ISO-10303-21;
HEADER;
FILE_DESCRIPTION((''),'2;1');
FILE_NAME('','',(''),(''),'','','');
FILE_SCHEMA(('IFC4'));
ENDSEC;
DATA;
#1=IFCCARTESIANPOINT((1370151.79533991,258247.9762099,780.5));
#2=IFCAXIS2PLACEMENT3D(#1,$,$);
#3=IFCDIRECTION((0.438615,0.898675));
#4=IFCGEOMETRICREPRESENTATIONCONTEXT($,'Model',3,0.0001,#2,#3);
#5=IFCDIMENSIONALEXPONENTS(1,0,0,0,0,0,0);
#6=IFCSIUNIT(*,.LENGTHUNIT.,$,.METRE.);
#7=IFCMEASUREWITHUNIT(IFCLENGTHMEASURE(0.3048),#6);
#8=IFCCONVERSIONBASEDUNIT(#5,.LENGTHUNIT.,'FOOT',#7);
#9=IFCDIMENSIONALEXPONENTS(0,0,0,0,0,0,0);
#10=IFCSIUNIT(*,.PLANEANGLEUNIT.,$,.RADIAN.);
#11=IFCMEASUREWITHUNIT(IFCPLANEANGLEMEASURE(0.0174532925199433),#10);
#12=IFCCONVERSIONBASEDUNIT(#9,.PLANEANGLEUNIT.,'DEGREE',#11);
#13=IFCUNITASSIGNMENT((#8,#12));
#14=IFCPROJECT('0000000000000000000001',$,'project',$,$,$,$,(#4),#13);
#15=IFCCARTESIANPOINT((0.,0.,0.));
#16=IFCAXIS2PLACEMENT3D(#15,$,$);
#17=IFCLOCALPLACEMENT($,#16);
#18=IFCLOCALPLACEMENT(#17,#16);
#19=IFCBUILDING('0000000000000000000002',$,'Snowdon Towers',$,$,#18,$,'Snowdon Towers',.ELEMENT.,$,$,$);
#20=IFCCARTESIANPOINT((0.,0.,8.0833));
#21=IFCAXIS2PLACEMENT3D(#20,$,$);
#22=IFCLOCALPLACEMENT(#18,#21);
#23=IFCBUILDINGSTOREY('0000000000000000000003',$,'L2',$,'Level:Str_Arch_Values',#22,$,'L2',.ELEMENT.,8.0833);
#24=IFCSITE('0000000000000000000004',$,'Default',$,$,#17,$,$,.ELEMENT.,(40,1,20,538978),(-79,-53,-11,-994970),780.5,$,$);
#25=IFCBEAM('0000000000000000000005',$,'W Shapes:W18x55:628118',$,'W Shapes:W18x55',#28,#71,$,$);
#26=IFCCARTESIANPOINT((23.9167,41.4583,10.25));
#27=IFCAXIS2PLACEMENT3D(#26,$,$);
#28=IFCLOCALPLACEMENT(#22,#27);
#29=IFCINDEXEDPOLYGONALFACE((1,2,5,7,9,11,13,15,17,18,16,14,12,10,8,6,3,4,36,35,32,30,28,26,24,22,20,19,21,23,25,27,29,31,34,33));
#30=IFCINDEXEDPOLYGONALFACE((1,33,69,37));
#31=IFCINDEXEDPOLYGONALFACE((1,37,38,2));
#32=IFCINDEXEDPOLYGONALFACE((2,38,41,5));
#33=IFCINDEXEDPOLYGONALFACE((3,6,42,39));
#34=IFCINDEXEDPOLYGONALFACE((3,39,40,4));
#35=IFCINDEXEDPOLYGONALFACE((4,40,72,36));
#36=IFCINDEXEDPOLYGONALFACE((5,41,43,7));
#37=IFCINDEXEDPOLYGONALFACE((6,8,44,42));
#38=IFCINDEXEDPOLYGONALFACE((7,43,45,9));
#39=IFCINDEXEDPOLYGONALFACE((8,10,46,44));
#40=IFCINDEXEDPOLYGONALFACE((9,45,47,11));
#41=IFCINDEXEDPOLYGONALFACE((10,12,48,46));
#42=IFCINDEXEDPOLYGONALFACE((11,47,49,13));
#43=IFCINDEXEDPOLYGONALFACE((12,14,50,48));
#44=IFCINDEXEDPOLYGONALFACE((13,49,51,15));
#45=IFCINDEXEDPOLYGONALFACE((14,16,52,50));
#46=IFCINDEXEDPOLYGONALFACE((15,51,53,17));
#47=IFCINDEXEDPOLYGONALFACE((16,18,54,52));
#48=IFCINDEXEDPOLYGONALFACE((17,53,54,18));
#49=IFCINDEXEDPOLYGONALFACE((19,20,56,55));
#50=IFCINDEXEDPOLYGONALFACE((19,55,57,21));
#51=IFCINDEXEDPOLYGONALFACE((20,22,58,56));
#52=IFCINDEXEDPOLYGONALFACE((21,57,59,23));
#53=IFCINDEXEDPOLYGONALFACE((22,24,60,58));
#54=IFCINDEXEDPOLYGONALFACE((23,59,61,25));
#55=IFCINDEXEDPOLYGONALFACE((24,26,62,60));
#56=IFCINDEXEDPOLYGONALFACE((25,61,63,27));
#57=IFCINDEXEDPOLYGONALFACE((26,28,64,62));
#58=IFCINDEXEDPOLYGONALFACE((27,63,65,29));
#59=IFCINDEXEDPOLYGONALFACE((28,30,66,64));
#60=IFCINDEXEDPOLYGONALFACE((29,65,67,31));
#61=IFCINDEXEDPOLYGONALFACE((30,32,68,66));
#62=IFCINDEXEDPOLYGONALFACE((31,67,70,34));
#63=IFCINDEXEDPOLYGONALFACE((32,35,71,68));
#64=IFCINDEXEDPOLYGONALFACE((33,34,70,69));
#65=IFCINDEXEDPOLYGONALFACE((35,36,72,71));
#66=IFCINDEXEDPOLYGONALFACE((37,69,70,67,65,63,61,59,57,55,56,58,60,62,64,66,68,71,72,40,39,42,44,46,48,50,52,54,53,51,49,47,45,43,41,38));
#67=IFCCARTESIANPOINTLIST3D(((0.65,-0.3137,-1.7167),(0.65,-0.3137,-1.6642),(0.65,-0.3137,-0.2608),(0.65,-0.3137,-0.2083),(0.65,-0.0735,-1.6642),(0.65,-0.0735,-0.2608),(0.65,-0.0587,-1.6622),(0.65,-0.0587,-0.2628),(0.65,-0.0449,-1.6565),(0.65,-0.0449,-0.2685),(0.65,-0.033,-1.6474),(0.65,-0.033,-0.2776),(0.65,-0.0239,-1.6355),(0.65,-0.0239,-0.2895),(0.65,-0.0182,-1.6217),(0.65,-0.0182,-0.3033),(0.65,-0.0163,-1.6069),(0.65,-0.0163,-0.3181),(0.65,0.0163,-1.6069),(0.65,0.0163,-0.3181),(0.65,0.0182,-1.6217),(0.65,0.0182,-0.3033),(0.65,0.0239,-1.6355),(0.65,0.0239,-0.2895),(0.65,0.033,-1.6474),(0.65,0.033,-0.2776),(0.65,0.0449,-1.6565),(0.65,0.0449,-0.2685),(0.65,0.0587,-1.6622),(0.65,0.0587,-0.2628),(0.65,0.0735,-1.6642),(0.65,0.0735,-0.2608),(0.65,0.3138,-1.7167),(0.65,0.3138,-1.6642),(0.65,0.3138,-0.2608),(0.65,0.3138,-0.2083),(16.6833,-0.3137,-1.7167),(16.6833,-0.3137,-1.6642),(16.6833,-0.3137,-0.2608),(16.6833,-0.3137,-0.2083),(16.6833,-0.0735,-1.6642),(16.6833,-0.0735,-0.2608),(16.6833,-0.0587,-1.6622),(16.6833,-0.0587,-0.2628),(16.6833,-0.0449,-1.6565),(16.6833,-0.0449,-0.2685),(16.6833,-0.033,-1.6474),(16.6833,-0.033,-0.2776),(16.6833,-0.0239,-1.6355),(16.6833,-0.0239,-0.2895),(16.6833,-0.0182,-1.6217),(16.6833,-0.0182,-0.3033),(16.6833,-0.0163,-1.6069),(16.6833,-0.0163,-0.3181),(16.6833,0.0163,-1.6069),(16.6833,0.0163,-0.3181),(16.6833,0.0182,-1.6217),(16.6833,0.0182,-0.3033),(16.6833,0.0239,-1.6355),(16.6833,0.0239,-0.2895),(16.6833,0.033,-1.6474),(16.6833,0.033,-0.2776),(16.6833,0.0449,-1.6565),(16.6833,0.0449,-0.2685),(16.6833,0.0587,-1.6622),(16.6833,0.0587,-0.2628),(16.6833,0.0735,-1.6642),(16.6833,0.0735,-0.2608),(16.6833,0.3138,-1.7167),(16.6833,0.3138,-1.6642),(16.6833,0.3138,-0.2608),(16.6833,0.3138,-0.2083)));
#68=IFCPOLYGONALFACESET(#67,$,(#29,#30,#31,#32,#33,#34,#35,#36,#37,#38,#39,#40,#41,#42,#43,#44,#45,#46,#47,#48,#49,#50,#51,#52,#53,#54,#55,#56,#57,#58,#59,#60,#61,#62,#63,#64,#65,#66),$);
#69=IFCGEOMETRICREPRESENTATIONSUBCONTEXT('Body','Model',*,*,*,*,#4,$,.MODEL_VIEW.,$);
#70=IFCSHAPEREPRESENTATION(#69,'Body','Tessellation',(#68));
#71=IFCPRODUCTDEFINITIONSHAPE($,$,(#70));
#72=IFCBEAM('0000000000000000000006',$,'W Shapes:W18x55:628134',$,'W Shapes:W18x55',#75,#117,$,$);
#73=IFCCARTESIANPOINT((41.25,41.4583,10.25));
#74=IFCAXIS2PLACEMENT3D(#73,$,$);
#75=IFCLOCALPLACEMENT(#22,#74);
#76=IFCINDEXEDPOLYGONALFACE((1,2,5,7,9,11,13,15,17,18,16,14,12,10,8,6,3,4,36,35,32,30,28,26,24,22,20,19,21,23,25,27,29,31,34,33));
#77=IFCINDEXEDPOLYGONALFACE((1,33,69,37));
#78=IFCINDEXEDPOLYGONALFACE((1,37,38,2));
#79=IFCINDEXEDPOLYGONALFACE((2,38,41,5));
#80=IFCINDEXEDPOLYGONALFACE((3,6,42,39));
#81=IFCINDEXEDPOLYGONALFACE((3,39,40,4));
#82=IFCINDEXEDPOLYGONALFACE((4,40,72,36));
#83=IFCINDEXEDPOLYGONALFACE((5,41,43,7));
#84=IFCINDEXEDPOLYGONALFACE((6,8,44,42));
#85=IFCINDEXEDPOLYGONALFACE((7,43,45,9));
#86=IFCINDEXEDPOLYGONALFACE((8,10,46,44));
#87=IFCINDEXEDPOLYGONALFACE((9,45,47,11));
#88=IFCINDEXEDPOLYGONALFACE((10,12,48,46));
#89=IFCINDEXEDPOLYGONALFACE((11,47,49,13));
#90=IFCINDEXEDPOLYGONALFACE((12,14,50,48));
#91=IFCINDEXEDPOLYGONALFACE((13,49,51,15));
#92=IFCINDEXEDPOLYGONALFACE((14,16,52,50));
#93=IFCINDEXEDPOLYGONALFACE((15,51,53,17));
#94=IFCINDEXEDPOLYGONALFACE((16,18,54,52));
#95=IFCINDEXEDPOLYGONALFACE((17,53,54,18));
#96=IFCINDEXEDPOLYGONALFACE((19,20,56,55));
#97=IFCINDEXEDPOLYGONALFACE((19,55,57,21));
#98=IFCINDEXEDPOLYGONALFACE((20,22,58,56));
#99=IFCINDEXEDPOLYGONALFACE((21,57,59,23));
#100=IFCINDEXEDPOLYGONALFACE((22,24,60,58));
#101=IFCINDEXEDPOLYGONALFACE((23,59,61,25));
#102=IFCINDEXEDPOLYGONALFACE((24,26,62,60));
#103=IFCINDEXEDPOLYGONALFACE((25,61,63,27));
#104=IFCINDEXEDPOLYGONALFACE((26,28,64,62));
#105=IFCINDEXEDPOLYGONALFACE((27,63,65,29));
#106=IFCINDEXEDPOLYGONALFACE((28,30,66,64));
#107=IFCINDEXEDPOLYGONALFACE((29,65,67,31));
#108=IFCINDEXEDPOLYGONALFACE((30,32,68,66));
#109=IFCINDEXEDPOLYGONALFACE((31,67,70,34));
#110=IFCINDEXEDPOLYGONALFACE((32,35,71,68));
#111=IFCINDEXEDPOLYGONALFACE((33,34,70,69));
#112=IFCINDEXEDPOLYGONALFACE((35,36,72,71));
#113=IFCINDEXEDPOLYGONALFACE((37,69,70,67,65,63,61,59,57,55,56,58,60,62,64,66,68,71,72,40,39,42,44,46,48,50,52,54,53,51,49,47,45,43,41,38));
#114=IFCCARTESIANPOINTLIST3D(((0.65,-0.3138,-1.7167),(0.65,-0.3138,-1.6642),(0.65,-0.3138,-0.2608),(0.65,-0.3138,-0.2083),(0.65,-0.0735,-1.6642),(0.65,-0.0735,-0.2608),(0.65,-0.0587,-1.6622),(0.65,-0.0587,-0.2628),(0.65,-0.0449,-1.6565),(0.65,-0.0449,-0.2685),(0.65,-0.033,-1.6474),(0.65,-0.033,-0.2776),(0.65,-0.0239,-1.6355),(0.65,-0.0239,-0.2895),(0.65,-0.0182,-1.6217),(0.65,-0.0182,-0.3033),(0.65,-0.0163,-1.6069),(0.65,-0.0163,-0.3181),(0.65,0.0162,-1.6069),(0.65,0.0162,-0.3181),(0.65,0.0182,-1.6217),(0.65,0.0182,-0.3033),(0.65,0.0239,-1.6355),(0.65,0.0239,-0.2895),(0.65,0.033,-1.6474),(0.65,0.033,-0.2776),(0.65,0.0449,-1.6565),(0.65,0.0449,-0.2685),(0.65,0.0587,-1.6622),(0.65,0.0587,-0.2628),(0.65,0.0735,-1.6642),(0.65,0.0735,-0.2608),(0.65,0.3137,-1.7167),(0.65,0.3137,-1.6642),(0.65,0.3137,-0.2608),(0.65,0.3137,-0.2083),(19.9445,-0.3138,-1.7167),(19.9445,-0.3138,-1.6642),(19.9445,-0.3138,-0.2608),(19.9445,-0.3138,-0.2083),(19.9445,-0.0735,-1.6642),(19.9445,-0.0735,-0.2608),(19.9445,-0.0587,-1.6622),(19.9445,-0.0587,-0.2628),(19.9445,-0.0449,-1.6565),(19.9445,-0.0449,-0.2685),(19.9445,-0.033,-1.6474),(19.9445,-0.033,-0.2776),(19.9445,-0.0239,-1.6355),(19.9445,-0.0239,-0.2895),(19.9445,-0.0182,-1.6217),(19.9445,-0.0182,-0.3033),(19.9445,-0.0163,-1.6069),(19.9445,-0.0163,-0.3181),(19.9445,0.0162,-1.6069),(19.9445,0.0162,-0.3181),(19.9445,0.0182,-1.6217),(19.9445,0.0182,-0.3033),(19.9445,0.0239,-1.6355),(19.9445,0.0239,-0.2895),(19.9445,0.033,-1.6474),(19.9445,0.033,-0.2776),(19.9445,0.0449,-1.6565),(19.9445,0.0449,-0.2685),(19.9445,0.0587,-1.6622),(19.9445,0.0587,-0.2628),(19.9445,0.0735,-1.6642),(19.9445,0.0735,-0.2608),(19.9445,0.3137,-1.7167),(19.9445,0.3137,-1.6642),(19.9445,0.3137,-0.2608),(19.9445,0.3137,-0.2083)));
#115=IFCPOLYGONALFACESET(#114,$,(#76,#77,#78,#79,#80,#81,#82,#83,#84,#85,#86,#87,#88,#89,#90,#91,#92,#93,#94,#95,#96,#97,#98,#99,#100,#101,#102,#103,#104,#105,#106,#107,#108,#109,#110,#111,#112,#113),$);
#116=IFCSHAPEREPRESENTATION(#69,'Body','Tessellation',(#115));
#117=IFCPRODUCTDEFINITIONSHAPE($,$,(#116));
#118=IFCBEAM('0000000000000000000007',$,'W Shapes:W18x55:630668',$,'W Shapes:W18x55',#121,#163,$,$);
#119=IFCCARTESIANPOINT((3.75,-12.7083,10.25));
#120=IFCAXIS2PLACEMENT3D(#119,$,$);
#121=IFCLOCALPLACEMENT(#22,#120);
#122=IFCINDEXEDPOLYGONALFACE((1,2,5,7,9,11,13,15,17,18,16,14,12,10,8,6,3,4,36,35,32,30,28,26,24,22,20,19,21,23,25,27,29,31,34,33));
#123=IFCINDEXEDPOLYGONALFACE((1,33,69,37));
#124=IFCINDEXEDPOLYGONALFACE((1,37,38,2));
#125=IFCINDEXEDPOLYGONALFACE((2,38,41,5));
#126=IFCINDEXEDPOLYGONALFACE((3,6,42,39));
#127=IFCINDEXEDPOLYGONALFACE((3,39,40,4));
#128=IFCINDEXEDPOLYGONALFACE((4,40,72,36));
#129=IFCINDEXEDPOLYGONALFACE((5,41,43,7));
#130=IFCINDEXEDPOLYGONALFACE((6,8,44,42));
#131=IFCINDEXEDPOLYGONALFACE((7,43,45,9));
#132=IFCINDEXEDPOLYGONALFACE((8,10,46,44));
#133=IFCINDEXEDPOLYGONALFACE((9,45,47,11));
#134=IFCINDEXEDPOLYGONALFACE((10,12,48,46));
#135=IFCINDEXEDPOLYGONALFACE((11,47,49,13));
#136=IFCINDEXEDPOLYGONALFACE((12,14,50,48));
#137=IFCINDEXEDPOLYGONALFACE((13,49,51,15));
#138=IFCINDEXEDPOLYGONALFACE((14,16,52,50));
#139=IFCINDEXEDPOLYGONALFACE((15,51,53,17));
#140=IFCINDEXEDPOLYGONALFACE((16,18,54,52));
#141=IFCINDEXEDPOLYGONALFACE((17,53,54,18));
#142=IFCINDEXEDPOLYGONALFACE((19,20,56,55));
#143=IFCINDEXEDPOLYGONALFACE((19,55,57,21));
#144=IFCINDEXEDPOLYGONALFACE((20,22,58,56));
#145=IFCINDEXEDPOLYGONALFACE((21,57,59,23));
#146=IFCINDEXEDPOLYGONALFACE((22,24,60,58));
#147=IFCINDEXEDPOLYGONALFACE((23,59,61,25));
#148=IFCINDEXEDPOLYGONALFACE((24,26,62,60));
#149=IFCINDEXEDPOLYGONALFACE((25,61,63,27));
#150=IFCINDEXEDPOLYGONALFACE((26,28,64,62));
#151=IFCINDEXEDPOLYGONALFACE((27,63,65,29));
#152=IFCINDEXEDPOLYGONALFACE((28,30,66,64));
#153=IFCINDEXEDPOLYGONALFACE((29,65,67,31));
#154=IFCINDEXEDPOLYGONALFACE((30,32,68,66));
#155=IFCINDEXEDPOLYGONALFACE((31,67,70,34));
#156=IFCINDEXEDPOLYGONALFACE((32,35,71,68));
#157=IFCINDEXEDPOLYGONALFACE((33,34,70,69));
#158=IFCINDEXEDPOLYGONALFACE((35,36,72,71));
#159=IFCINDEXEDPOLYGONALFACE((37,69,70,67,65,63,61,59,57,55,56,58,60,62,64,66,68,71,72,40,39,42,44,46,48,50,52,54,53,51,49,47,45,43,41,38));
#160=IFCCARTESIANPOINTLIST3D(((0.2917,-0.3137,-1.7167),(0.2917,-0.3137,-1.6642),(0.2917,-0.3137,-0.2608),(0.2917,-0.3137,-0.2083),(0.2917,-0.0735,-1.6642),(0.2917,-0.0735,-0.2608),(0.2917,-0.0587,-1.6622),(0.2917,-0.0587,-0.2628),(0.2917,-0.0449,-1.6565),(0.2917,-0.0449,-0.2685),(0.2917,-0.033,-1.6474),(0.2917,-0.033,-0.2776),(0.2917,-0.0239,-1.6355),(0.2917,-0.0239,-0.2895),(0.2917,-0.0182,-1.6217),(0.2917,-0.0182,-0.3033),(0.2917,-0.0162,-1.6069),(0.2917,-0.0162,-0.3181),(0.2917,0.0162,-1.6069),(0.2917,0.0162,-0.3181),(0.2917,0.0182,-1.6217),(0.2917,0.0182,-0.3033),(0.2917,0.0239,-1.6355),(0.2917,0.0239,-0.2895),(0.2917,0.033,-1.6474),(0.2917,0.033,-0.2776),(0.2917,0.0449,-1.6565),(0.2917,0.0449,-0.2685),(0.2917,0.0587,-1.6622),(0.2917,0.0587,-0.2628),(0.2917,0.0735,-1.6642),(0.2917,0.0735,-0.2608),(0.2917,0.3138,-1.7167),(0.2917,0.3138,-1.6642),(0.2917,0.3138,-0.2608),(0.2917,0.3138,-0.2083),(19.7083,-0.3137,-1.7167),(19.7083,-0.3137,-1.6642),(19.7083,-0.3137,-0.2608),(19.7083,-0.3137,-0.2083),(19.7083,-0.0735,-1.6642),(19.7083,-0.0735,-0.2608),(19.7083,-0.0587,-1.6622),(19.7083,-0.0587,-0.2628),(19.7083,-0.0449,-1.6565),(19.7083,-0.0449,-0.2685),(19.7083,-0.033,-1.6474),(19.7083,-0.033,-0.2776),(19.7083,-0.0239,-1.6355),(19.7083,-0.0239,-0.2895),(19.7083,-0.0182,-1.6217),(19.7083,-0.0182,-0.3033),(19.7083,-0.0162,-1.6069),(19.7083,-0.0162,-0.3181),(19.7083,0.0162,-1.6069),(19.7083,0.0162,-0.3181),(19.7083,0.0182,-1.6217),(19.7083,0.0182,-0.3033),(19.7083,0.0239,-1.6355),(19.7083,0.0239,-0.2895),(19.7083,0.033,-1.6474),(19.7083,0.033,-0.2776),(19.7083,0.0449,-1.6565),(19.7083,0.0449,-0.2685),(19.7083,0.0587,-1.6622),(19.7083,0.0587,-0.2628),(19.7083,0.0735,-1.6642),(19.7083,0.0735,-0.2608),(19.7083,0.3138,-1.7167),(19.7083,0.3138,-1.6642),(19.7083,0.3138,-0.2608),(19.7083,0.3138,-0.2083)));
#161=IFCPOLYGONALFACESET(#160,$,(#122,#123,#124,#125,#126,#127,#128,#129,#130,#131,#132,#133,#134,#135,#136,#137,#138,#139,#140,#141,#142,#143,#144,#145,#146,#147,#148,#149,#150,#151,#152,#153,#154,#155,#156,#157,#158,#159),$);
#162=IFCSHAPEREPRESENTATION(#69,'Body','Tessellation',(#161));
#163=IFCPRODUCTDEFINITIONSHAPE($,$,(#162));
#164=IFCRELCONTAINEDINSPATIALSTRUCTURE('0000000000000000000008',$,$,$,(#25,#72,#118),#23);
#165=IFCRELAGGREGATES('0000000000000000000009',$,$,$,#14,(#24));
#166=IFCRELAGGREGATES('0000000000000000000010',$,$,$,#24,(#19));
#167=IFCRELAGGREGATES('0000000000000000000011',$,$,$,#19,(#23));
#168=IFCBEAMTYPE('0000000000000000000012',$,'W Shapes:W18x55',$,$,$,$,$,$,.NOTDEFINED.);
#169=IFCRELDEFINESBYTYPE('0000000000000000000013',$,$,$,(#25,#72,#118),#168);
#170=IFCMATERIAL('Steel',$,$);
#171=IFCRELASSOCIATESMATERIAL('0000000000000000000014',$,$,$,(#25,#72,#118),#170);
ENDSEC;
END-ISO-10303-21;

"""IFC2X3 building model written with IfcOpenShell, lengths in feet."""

from ifc_helpers import new_model, entity, si_unit, converted_unit, direction, frame, frame_2d, origin, place, context, subcontext, project, spatial, i_section, extrude, material, type_object, element, save


model = new_model("IFC2X3")

# Units and contexts
model_context = context("Model", 3, precision=0.0001, world=frame((1370151.79533991, 258247.9762099, 780.5)), true_north=direction((0.438615, 0.898675)))
body_context = subcontext(model_context, "Body", "Model", "MODEL_VIEW")
ifc_project = project(units=[converted_unit("LENGTHUNIT", "FOOT", entity("IfcLengthMeasure", 0.3048), si_unit("LENGTHUNIT", "METRE"), dimensions=[1, 0, 0, 0, 0, 0, 0]), converted_unit("PLANEANGLEUNIT", "DEGREE", entity("IfcPlaneAngleMeasure", 0.0174532925199433), si_unit("PLANEANGLEUNIT", "RADIAN"), dimensions=[0, 0, 0, 0, 0, 0, 0])], contexts=[model_context])

# Site, building, storey
site_placement = place(None, origin())
site = spatial("IfcSite", under=ifc_project, at=site_placement, Name="Default", CompositionType="ELEMENT", RefLatitude=(40, 1, 20, 538978), RefLongitude=(-79, -53, -11, -994970), RefElevation=780.5)
building_placement = place(site_placement, origin())
building = spatial("IfcBuilding", under=site, at=building_placement, Name="Snowdon Towers", LongName="Snowdon Towers", CompositionType="ELEMENT")
storey_placement = place(building_placement, frame((0.0, 0.0, 8.0833)))
storey = spatial("IfcBuildingStorey", under=building, at=storey_placement, Name="L2", ObjectType="Level:Str_Arch_Values", LongName="L2", CompositionType="ELEMENT", Elevation=8.0833)

# Beams
ifc_material = material(Name="Steel")
beam_type_1 = type_object("IfcBeamType", Name="W Shapes:W18x55", PredefinedType="NOTDEFINED")
beam_1_placement = place(storey_placement, frame((23.9167, 41.4583, 10.25)))
element("IfcBeam", 1, at=beam_1_placement, inside=storey, type_object=beam_type_1, material=ifc_material, Name="W Shapes:W18x55:628118", ObjectType="W Shapes:W18x55", context=body_context, shape_type="SweptSolid", body=[
    extrude(i_section(OverallWidth=0.6275, OverallDepth=1.5083, WebThickness=0.0325, FlangeThickness=0.0525, FilletRadius=0.0573, at=frame_2d((0.0, 0.0), x_axis=(0.0, 1.0))), frame((0.65, 0.0, -0.9625), z_axis=(1.0, 0.0, 0.0), x_axis=(0.0, 0.0, -1.0)), (0.0, 0.0, 1.0), 16.0333),
])
beam_2_placement = place(storey_placement, frame((41.25, 41.4583, 10.25)))
element("IfcBeam", 2, at=beam_2_placement, inside=storey, type_object=beam_type_1, material=ifc_material, Name="W Shapes:W18x55:628134", ObjectType="W Shapes:W18x55", context=body_context, shape_type="SweptSolid", body=[
    extrude(i_section(OverallWidth=0.6275, OverallDepth=1.5083, WebThickness=0.0325, FlangeThickness=0.0525, FilletRadius=0.0573, at=frame_2d((0.0, 0.0), x_axis=(0.0, 1.0))), frame((0.65, 0.0, -0.9625), z_axis=(1.0, 0.0, 0.0), x_axis=(0.0, 0.0, -1.0)), (0.0, 0.0, 1.0), 19.2945),
])
beam_3_placement = place(storey_placement, frame((3.75, -12.7083, 10.25)))
element("IfcBeam", 3, at=beam_3_placement, inside=storey, type_object=beam_type_1, material=ifc_material, Name="W Shapes:W18x55:630668", ObjectType="W Shapes:W18x55", context=body_context, shape_type="SweptSolid", body=[
    extrude(i_section(OverallWidth=0.6275, OverallDepth=1.5083, WebThickness=0.0325, FlangeThickness=0.0525, FilletRadius=0.0573, at=frame_2d((0.0, 0.0), x_axis=(0.0, 1.0))), frame((0.2917, 0.0, -0.9625), z_axis=(1.0, 0.0, 0.0), x_axis=(0.0, 0.0, -1.0)), (0.0, 0.0, 1.0), 19.4167),
])

save(model, "model.ifc")
